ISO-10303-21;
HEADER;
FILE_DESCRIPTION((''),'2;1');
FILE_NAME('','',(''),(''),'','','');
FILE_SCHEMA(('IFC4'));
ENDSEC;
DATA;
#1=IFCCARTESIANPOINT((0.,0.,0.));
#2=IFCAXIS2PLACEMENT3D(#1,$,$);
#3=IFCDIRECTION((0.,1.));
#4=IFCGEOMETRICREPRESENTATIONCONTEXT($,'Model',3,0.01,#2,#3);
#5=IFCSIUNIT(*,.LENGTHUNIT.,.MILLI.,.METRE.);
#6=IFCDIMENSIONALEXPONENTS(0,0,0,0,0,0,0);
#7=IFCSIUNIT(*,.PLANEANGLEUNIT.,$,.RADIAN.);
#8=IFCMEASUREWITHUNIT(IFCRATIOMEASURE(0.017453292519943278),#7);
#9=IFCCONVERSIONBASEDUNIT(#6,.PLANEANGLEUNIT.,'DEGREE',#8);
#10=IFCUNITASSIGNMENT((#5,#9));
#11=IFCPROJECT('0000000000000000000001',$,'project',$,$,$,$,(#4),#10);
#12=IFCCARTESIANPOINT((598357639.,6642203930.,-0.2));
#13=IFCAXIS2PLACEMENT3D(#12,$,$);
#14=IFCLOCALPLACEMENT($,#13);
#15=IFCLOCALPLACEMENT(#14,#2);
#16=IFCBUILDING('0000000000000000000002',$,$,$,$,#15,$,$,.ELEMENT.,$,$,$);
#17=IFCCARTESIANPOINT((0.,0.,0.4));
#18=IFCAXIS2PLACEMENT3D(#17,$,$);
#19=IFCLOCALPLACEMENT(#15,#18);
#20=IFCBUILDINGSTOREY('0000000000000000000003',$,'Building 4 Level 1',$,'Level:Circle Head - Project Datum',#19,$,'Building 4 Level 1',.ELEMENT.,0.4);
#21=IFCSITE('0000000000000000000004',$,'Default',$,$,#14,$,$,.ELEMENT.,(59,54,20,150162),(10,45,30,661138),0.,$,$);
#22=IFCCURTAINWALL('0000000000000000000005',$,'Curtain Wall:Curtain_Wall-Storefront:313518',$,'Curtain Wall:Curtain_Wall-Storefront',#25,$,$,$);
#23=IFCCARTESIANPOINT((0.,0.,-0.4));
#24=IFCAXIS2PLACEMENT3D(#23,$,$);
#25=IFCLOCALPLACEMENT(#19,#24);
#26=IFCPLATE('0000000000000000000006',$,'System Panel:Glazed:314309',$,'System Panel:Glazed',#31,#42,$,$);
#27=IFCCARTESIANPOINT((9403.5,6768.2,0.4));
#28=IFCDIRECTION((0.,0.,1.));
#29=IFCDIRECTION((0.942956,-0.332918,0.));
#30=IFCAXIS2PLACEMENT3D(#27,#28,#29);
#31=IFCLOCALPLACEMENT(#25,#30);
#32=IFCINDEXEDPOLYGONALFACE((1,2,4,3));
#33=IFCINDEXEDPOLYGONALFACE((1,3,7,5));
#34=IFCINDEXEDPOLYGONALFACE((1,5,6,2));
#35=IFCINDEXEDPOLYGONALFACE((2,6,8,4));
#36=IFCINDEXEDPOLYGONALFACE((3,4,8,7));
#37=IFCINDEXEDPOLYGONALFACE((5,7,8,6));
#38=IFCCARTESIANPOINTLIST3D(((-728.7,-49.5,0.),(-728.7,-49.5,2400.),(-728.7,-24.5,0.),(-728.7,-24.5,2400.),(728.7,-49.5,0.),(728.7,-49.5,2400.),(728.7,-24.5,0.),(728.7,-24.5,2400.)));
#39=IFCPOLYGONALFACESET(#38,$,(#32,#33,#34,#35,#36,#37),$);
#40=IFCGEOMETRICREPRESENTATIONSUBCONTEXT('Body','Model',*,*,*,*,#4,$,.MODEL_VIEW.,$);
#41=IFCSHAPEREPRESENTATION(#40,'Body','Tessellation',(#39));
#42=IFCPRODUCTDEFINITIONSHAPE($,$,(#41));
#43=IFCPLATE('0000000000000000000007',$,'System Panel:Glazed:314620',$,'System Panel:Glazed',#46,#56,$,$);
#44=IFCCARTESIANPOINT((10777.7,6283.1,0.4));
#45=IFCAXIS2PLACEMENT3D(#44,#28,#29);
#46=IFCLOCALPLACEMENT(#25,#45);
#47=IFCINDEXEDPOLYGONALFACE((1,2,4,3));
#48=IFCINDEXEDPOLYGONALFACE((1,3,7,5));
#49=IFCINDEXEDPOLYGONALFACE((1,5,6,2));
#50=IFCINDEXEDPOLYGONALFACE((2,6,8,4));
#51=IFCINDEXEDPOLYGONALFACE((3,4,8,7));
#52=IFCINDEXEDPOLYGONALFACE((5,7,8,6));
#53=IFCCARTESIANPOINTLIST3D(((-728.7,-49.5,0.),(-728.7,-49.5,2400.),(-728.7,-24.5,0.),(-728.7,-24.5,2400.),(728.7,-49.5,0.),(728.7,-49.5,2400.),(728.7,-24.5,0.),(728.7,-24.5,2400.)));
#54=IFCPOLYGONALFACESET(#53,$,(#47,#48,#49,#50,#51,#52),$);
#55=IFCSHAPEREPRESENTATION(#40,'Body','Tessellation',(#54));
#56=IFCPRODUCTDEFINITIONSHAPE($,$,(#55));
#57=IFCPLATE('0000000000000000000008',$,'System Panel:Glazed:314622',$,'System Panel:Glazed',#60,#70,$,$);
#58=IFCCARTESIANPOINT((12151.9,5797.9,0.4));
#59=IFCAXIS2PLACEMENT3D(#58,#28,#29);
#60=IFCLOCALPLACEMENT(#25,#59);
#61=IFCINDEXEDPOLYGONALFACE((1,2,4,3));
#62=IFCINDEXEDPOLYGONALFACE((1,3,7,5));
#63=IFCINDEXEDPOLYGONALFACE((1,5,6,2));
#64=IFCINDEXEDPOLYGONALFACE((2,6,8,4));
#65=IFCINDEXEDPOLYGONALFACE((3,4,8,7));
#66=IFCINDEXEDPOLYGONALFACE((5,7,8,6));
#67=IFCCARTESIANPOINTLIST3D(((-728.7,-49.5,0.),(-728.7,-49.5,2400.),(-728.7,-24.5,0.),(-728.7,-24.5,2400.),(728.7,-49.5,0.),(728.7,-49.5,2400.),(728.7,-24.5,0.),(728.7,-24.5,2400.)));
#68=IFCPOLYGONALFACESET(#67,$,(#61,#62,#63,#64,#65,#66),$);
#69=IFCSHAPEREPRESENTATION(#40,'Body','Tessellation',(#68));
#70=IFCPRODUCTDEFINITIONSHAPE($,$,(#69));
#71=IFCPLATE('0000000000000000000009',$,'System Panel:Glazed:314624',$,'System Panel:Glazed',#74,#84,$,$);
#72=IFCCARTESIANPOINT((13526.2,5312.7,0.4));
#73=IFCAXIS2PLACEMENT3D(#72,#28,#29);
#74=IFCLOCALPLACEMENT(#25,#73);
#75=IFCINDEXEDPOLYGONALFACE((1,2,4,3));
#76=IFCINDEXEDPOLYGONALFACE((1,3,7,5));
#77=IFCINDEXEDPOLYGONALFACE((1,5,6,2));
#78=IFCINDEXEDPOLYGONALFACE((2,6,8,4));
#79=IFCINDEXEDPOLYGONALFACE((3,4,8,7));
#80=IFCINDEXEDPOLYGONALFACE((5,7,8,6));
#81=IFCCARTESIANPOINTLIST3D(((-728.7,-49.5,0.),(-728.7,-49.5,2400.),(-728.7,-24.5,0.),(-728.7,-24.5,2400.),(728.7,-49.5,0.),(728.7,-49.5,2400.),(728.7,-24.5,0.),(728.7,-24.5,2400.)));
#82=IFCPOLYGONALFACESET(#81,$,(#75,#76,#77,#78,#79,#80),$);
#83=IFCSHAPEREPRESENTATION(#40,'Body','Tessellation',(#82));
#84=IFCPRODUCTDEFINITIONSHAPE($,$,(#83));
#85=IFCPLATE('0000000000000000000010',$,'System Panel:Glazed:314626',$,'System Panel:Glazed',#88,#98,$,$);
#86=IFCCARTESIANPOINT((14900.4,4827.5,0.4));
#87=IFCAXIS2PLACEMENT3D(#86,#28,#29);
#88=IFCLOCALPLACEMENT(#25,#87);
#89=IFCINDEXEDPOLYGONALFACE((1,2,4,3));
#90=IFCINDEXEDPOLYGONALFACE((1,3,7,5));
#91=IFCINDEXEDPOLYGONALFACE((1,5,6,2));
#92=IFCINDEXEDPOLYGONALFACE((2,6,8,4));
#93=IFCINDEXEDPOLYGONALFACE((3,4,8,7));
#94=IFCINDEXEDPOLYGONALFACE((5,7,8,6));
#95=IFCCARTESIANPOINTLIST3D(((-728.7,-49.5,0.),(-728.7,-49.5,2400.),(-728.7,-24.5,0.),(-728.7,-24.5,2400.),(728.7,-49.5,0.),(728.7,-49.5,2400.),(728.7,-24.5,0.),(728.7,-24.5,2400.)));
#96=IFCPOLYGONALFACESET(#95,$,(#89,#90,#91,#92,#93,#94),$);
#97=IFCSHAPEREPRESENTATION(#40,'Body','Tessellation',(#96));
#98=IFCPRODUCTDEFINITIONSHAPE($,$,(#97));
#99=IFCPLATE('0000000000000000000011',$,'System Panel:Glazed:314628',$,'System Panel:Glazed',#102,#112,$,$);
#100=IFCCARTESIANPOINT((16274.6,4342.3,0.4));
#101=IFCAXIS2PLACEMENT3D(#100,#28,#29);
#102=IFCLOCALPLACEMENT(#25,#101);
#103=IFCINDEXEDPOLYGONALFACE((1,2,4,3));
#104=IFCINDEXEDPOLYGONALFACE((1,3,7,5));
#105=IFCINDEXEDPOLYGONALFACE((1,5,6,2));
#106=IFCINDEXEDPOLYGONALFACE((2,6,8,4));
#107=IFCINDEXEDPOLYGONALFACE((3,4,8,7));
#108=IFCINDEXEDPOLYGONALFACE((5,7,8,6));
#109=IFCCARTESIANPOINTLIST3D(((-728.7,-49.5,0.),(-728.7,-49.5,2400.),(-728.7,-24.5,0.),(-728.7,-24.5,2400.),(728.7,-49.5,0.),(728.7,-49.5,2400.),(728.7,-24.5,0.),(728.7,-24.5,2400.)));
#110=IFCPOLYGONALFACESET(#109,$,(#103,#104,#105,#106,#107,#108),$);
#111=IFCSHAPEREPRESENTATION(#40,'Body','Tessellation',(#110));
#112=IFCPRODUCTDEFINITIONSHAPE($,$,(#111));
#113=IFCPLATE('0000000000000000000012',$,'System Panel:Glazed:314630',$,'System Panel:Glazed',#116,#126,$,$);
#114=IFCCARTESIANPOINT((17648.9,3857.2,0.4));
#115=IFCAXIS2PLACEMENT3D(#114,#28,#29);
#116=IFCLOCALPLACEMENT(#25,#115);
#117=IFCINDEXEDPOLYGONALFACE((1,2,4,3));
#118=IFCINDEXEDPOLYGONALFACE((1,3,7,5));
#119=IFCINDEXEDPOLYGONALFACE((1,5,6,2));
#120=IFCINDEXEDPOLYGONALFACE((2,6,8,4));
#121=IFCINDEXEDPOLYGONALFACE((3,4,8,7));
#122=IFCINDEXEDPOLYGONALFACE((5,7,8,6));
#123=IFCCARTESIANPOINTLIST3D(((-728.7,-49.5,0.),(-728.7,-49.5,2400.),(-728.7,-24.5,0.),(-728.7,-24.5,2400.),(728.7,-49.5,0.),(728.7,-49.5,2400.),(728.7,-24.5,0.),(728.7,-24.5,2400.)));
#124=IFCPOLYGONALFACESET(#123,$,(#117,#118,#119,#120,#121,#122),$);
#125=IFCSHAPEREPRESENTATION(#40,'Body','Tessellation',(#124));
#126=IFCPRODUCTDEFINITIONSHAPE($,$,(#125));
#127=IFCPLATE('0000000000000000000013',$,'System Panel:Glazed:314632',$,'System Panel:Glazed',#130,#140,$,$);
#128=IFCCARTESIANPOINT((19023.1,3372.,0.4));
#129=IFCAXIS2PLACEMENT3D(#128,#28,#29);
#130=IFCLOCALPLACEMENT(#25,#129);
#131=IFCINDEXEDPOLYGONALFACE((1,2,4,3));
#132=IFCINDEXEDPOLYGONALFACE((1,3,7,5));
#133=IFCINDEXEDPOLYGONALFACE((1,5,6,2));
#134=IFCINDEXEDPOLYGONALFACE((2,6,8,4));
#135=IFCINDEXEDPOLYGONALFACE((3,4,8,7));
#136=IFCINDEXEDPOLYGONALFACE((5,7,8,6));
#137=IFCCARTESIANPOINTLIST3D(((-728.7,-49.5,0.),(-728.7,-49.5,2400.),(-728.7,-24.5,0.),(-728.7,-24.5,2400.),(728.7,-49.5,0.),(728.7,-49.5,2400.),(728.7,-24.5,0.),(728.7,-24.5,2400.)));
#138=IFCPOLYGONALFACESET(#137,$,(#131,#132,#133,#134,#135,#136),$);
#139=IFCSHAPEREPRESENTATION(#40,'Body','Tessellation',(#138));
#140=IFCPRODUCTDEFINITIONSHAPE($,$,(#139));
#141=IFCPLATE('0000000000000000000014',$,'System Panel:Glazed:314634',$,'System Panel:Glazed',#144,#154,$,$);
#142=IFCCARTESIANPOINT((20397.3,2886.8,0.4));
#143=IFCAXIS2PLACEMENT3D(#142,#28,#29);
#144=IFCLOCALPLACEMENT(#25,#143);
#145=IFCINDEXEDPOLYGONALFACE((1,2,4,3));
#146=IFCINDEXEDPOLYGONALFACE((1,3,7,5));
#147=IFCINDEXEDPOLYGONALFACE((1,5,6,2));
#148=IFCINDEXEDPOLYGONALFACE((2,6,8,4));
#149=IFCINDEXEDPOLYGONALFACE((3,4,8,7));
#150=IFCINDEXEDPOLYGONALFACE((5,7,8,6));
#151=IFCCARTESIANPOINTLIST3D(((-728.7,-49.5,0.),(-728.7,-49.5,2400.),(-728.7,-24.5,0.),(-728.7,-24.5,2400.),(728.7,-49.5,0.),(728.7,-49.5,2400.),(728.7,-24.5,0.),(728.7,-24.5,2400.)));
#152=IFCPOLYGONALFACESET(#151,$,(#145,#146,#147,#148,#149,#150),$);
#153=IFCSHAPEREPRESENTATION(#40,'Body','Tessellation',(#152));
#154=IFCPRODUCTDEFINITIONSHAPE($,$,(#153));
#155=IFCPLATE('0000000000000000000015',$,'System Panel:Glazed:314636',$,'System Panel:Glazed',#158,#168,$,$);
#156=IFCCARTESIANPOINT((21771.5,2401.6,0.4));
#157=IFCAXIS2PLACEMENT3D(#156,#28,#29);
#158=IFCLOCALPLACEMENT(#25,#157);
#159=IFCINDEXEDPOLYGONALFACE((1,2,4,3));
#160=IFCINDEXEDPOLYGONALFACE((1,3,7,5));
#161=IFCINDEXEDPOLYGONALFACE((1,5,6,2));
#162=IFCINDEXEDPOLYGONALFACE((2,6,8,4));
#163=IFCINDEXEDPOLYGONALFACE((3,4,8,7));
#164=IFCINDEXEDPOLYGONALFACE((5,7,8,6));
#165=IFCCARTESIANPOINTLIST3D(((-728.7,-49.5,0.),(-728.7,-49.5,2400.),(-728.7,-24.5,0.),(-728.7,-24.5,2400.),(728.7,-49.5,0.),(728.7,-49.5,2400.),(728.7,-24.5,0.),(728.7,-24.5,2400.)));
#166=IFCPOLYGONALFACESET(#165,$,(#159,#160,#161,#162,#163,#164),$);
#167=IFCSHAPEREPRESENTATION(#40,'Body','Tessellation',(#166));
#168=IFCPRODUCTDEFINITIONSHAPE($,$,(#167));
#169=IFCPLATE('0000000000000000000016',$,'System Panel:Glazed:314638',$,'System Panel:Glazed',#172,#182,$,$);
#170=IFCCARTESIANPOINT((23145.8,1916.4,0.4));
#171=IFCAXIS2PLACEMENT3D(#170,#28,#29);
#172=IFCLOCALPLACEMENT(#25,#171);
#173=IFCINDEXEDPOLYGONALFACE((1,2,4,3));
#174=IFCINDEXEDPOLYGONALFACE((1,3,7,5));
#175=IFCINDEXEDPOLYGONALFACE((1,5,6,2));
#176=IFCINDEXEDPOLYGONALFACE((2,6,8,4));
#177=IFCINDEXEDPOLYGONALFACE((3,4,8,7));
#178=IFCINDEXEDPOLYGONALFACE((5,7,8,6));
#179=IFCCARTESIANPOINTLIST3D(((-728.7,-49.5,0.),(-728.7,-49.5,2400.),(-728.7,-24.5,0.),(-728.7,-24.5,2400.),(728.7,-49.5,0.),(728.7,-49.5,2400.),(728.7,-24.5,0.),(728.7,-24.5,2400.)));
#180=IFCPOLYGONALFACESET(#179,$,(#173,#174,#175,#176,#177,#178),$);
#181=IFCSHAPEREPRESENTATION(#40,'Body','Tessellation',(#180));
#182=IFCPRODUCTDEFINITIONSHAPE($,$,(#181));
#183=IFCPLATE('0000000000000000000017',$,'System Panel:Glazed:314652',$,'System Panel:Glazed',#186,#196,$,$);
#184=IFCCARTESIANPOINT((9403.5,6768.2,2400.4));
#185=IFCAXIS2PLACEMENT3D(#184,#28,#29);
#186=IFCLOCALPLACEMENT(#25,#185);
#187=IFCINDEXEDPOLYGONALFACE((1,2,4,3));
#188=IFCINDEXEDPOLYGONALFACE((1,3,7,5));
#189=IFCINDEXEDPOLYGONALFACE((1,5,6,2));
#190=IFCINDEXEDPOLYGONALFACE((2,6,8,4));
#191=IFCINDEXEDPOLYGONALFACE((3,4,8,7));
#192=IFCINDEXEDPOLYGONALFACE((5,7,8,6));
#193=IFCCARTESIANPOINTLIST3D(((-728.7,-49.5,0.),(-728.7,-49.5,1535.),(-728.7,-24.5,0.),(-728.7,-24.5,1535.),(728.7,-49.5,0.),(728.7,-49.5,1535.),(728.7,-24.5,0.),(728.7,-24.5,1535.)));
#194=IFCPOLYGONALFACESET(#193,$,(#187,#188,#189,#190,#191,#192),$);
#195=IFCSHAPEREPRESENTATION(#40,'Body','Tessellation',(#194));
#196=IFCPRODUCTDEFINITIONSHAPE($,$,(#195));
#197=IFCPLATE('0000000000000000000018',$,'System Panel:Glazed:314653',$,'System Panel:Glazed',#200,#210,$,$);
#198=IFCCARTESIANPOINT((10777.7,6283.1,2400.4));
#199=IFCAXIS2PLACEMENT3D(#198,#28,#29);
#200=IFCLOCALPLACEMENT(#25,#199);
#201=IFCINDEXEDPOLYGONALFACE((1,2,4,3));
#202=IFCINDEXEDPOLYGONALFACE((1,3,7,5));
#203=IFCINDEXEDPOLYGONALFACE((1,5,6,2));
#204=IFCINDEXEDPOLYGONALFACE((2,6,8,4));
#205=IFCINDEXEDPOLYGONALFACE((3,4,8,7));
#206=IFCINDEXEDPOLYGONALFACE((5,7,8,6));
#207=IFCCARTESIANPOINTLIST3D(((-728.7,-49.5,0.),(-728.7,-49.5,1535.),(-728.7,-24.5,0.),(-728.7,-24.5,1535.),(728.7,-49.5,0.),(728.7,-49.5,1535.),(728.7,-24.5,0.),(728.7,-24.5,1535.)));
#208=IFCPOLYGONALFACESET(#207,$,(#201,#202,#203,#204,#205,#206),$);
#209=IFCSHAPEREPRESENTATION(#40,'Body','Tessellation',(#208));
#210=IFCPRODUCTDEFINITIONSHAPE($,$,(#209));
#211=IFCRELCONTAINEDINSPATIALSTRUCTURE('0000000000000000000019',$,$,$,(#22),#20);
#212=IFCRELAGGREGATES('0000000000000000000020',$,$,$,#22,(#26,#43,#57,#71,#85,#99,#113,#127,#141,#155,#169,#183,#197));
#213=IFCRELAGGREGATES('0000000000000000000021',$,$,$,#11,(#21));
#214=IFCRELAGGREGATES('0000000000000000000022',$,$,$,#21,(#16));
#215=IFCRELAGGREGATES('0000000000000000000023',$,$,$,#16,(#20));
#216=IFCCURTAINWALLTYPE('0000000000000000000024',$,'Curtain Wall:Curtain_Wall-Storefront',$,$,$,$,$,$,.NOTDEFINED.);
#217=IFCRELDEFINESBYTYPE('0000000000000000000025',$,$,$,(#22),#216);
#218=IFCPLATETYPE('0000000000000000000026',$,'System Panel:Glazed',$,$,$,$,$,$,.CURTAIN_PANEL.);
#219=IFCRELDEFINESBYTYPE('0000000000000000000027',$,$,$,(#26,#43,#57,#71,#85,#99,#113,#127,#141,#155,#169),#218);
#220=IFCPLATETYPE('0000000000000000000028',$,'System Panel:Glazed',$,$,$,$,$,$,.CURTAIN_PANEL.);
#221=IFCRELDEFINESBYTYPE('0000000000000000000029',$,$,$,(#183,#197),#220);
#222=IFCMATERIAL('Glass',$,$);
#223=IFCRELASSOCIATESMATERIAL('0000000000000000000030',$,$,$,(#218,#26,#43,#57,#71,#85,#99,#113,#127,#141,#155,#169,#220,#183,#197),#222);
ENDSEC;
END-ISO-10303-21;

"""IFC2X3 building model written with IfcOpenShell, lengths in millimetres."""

from ifc_helpers import new_model, entity, si_unit, converted_unit, direction, frame, frame_2d, origin, place, context, subcontext, project, spatial, rectangle, extrude, source, transform, mapped, material, type_object, type_shapes, element, aggregate, save


model = new_model("IFC2X3")

# Units and contexts
model_context = context("Model", 3, precision=0.01, world=origin(), true_north=direction((0.0, 1.0)))
body_context = subcontext(model_context, "Body", "Model", "MODEL_VIEW")
ifc_project = project(units=[si_unit("LENGTHUNIT", "METRE", prefix="MILLI"), converted_unit("PLANEANGLEUNIT", "DEGREE", entity("IfcRatioMeasure", 0.017453292519943278), si_unit("PLANEANGLEUNIT", "RADIAN"), dimensions=[0, 0, 0, 0, 0, 0, 0])], contexts=[model_context])

# Site, building, storey
site_placement = place(None, frame((598357639.0, 6642203930.0, -0.2)))
site = spatial("IfcSite", under=ifc_project, at=site_placement, Name="Default", CompositionType="ELEMENT", RefLatitude=(59, 54, 20, 150162), RefLongitude=(10, 45, 30, 661138), RefElevation=0.0)
building_placement = place(site_placement, origin())
building = spatial("IfcBuilding", under=site, at=building_placement, CompositionType="ELEMENT")
storey_placement = place(building_placement, frame((0.0, 0.0, 0.4)))
storey = spatial("IfcBuildingStorey", under=building, at=storey_placement, Name="Building 4 Level 1", ObjectType="Level:Circle Head - Project Datum", LongName="Building 4 Level 1", CompositionType="ELEMENT", Elevation=0.4)

# Curtain wall, plates
curtain_wall_type = type_object("IfcCurtainWallType", Name="Curtain Wall:Curtain_Wall-Storefront", PredefinedType="NOTDEFINED")
curtain_wall_1_placement = place(storey_placement, frame((0.0, 0.0, -0.4)))
curtain_wall_1 = element("IfcCurtainWall", 1, at=curtain_wall_1_placement, inside=storey, type_object=curtain_wall_type, Name="Curtain Wall:Curtain_Wall-Storefront:313518", ObjectType="Curtain Wall:Curtain_Wall-Storefront")
ifc_material_1 = material(Name="Glass")
plate_type_1 = type_object("IfcPlateType", Name="System Panel:Glazed", PredefinedType="CURTAIN_PANEL", material=ifc_material_1)
shared_shape_1 = source(origin(), body_context, "Body", "SweptSolid", [
    extrude(rectangle(XDim=25.0, YDim=1457.4, at=frame_2d((0.0, 0.0), x_axis=(1.0, 0.0))), frame((0.0, -37.0, 0.0), z_axis=(0.0, 0.0, 1.0), x_axis=(0.0, 1.0, 0.0)), (0.0, 0.0, 1.0), 2400.0),
])
type_shapes(plate_type_1, [shared_shape_1])
plate_1_placement = place(curtain_wall_1_placement, frame((9403.5, 6768.2, 0.4), z_axis=(0.0, 0.0, 1.0), x_axis=(0.942956, -0.332918, 0.0)))
plate_1 = element("IfcPlate", 2, at=plate_1_placement, type_object=plate_type_1, material=ifc_material_1, Name="System Panel:Glazed:314309", ObjectType="System Panel:Glazed", context=body_context, shape_type="MappedRepresentation", body=[
    mapped(shared_shape_1, transform((0.0, 0.0, 0.0), scale=1.0)),
])
plate_2_placement = place(curtain_wall_1_placement, frame((10777.7, 6283.1, 0.4), z_axis=(0.0, 0.0, 1.0), x_axis=(0.942956, -0.332918, 0.0)))
plate_2 = element("IfcPlate", 3, at=plate_2_placement, type_object=plate_type_1, material=ifc_material_1, Name="System Panel:Glazed:314620", ObjectType="System Panel:Glazed", context=body_context, shape_type="MappedRepresentation", body=[
    mapped(shared_shape_1, transform((0.0, 0.0, 0.0), scale=1.0)),
])
plate_3_placement = place(curtain_wall_1_placement, frame((12151.9, 5797.9, 0.4), z_axis=(0.0, 0.0, 1.0), x_axis=(0.942956, -0.332918, 0.0)))
plate_3 = element("IfcPlate", 4, at=plate_3_placement, type_object=plate_type_1, material=ifc_material_1, Name="System Panel:Glazed:314622", ObjectType="System Panel:Glazed", context=body_context, shape_type="MappedRepresentation", body=[
    mapped(shared_shape_1, transform((0.0, 0.0, 0.0), scale=1.0)),
])
plate_4_placement = place(curtain_wall_1_placement, frame((13526.2, 5312.7, 0.4), z_axis=(0.0, 0.0, 1.0), x_axis=(0.942956, -0.332918, 0.0)))
plate_4 = element("IfcPlate", 5, at=plate_4_placement, type_object=plate_type_1, material=ifc_material_1, Name="System Panel:Glazed:314624", ObjectType="System Panel:Glazed", context=body_context, shape_type="MappedRepresentation", body=[
    mapped(shared_shape_1, transform((0.0, 0.0, 0.0), scale=1.0)),
])
plate_5_placement = place(curtain_wall_1_placement, frame((14900.4, 4827.5, 0.4), z_axis=(0.0, 0.0, 1.0), x_axis=(0.942956, -0.332918, 0.0)))
plate_5 = element("IfcPlate", 6, at=plate_5_placement, type_object=plate_type_1, material=ifc_material_1, Name="System Panel:Glazed:314626", ObjectType="System Panel:Glazed", context=body_context, shape_type="MappedRepresentation", body=[
    mapped(shared_shape_1, transform((0.0, 0.0, 0.0), scale=1.0)),
])
plate_6_placement = place(curtain_wall_1_placement, frame((16274.6, 4342.3, 0.4), z_axis=(0.0, 0.0, 1.0), x_axis=(0.942956, -0.332918, 0.0)))
plate_6 = element("IfcPlate", 7, at=plate_6_placement, type_object=plate_type_1, material=ifc_material_1, Name="System Panel:Glazed:314628", ObjectType="System Panel:Glazed", context=body_context, shape_type="MappedRepresentation", body=[
    mapped(shared_shape_1, transform((0.0, 0.0, 0.0), scale=1.0)),
])
plate_7_placement = place(curtain_wall_1_placement, frame((17648.9, 3857.2, 0.4), z_axis=(0.0, 0.0, 1.0), x_axis=(0.942956, -0.332918, 0.0)))
plate_7 = element("IfcPlate", 8, at=plate_7_placement, type_object=plate_type_1, material=ifc_material_1, Name="System Panel:Glazed:314630", ObjectType="System Panel:Glazed", context=body_context, shape_type="MappedRepresentation", body=[
    mapped(shared_shape_1, transform((0.0, 0.0, 0.0), scale=1.0)),
])
plate_8_placement = place(curtain_wall_1_placement, frame((19023.1, 3372.0, 0.4), z_axis=(0.0, 0.0, 1.0), x_axis=(0.942956, -0.332918, 0.0)))
plate_8 = element("IfcPlate", 9, at=plate_8_placement, type_object=plate_type_1, material=ifc_material_1, Name="System Panel:Glazed:314632", ObjectType="System Panel:Glazed", context=body_context, shape_type="MappedRepresentation", body=[
    mapped(shared_shape_1, transform((0.0, 0.0, 0.0), scale=1.0)),
])
plate_9_placement = place(curtain_wall_1_placement, frame((20397.3, 2886.8, 0.4), z_axis=(0.0, 0.0, 1.0), x_axis=(0.942956, -0.332918, 0.0)))
plate_9 = element("IfcPlate", 10, at=plate_9_placement, type_object=plate_type_1, material=ifc_material_1, Name="System Panel:Glazed:314634", ObjectType="System Panel:Glazed", context=body_context, shape_type="MappedRepresentation", body=[
    mapped(shared_shape_1, transform((0.0, 0.0, 0.0), scale=1.0)),
])
plate_10_placement = place(curtain_wall_1_placement, frame((21771.5, 2401.6, 0.4), z_axis=(0.0, 0.0, 1.0), x_axis=(0.942956, -0.332918, 0.0)))
plate_10 = element("IfcPlate", 11, at=plate_10_placement, type_object=plate_type_1, material=ifc_material_1, Name="System Panel:Glazed:314636", ObjectType="System Panel:Glazed", context=body_context, shape_type="MappedRepresentation", body=[
    mapped(shared_shape_1, transform((0.0, 0.0, 0.0), scale=1.0)),
])
plate_11_placement = place(curtain_wall_1_placement, frame((23145.8, 1916.4, 0.4), z_axis=(0.0, 0.0, 1.0), x_axis=(0.942956, -0.332918, 0.0)))
plate_11 = element("IfcPlate", 12, at=plate_11_placement, type_object=plate_type_1, material=ifc_material_1, Name="System Panel:Glazed:314638", ObjectType="System Panel:Glazed", context=body_context, shape_type="MappedRepresentation", body=[
    mapped(shared_shape_1, transform((0.0, 0.0, 0.0), scale=1.0)),
])
plate_type_2 = type_object("IfcPlateType", Name="System Panel:Glazed", PredefinedType="CURTAIN_PANEL", material=ifc_material_1)
shared_shape_2 = source(origin(), body_context, "Body", "SweptSolid", [
    extrude(rectangle(XDim=25.0, YDim=1457.4, at=frame_2d((0.0, 0.0), x_axis=(1.0, 0.0))), frame((0.0, -37.0, 0.0), z_axis=(0.0, 0.0, 1.0), x_axis=(0.0, 1.0, 0.0)), (0.0, 0.0, 1.0), 1535.0),
])
type_shapes(plate_type_2, [shared_shape_2])
plate_12_placement = place(curtain_wall_1_placement, frame((9403.5, 6768.2, 2400.4), z_axis=(0.0, 0.0, 1.0), x_axis=(0.942956, -0.332918, 0.0)))
plate_12 = element("IfcPlate", 13, at=plate_12_placement, type_object=plate_type_2, material=ifc_material_1, Name="System Panel:Glazed:314652", ObjectType="System Panel:Glazed", context=body_context, shape_type="MappedRepresentation", body=[
    mapped(shared_shape_2, transform((0.0, 0.0, 0.0), scale=1.0)),
])
plate_13_placement = place(curtain_wall_1_placement, frame((10777.7, 6283.1, 2400.4), z_axis=(0.0, 0.0, 1.0), x_axis=(0.942956, -0.332918, 0.0)))
plate_13 = element("IfcPlate", 14, at=plate_13_placement, type_object=plate_type_2, material=ifc_material_1, Name="System Panel:Glazed:314653", ObjectType="System Panel:Glazed", context=body_context, shape_type="MappedRepresentation", body=[
    mapped(shared_shape_2, transform((0.0, 0.0, 0.0), scale=1.0)),
])
aggregate(curtain_wall_1, [plate_1, plate_2, plate_3, plate_4, plate_5, plate_6, plate_7, plate_8, plate_9, plate_10, plate_11, plate_12, plate_13])

save(model, "model.ifc")
